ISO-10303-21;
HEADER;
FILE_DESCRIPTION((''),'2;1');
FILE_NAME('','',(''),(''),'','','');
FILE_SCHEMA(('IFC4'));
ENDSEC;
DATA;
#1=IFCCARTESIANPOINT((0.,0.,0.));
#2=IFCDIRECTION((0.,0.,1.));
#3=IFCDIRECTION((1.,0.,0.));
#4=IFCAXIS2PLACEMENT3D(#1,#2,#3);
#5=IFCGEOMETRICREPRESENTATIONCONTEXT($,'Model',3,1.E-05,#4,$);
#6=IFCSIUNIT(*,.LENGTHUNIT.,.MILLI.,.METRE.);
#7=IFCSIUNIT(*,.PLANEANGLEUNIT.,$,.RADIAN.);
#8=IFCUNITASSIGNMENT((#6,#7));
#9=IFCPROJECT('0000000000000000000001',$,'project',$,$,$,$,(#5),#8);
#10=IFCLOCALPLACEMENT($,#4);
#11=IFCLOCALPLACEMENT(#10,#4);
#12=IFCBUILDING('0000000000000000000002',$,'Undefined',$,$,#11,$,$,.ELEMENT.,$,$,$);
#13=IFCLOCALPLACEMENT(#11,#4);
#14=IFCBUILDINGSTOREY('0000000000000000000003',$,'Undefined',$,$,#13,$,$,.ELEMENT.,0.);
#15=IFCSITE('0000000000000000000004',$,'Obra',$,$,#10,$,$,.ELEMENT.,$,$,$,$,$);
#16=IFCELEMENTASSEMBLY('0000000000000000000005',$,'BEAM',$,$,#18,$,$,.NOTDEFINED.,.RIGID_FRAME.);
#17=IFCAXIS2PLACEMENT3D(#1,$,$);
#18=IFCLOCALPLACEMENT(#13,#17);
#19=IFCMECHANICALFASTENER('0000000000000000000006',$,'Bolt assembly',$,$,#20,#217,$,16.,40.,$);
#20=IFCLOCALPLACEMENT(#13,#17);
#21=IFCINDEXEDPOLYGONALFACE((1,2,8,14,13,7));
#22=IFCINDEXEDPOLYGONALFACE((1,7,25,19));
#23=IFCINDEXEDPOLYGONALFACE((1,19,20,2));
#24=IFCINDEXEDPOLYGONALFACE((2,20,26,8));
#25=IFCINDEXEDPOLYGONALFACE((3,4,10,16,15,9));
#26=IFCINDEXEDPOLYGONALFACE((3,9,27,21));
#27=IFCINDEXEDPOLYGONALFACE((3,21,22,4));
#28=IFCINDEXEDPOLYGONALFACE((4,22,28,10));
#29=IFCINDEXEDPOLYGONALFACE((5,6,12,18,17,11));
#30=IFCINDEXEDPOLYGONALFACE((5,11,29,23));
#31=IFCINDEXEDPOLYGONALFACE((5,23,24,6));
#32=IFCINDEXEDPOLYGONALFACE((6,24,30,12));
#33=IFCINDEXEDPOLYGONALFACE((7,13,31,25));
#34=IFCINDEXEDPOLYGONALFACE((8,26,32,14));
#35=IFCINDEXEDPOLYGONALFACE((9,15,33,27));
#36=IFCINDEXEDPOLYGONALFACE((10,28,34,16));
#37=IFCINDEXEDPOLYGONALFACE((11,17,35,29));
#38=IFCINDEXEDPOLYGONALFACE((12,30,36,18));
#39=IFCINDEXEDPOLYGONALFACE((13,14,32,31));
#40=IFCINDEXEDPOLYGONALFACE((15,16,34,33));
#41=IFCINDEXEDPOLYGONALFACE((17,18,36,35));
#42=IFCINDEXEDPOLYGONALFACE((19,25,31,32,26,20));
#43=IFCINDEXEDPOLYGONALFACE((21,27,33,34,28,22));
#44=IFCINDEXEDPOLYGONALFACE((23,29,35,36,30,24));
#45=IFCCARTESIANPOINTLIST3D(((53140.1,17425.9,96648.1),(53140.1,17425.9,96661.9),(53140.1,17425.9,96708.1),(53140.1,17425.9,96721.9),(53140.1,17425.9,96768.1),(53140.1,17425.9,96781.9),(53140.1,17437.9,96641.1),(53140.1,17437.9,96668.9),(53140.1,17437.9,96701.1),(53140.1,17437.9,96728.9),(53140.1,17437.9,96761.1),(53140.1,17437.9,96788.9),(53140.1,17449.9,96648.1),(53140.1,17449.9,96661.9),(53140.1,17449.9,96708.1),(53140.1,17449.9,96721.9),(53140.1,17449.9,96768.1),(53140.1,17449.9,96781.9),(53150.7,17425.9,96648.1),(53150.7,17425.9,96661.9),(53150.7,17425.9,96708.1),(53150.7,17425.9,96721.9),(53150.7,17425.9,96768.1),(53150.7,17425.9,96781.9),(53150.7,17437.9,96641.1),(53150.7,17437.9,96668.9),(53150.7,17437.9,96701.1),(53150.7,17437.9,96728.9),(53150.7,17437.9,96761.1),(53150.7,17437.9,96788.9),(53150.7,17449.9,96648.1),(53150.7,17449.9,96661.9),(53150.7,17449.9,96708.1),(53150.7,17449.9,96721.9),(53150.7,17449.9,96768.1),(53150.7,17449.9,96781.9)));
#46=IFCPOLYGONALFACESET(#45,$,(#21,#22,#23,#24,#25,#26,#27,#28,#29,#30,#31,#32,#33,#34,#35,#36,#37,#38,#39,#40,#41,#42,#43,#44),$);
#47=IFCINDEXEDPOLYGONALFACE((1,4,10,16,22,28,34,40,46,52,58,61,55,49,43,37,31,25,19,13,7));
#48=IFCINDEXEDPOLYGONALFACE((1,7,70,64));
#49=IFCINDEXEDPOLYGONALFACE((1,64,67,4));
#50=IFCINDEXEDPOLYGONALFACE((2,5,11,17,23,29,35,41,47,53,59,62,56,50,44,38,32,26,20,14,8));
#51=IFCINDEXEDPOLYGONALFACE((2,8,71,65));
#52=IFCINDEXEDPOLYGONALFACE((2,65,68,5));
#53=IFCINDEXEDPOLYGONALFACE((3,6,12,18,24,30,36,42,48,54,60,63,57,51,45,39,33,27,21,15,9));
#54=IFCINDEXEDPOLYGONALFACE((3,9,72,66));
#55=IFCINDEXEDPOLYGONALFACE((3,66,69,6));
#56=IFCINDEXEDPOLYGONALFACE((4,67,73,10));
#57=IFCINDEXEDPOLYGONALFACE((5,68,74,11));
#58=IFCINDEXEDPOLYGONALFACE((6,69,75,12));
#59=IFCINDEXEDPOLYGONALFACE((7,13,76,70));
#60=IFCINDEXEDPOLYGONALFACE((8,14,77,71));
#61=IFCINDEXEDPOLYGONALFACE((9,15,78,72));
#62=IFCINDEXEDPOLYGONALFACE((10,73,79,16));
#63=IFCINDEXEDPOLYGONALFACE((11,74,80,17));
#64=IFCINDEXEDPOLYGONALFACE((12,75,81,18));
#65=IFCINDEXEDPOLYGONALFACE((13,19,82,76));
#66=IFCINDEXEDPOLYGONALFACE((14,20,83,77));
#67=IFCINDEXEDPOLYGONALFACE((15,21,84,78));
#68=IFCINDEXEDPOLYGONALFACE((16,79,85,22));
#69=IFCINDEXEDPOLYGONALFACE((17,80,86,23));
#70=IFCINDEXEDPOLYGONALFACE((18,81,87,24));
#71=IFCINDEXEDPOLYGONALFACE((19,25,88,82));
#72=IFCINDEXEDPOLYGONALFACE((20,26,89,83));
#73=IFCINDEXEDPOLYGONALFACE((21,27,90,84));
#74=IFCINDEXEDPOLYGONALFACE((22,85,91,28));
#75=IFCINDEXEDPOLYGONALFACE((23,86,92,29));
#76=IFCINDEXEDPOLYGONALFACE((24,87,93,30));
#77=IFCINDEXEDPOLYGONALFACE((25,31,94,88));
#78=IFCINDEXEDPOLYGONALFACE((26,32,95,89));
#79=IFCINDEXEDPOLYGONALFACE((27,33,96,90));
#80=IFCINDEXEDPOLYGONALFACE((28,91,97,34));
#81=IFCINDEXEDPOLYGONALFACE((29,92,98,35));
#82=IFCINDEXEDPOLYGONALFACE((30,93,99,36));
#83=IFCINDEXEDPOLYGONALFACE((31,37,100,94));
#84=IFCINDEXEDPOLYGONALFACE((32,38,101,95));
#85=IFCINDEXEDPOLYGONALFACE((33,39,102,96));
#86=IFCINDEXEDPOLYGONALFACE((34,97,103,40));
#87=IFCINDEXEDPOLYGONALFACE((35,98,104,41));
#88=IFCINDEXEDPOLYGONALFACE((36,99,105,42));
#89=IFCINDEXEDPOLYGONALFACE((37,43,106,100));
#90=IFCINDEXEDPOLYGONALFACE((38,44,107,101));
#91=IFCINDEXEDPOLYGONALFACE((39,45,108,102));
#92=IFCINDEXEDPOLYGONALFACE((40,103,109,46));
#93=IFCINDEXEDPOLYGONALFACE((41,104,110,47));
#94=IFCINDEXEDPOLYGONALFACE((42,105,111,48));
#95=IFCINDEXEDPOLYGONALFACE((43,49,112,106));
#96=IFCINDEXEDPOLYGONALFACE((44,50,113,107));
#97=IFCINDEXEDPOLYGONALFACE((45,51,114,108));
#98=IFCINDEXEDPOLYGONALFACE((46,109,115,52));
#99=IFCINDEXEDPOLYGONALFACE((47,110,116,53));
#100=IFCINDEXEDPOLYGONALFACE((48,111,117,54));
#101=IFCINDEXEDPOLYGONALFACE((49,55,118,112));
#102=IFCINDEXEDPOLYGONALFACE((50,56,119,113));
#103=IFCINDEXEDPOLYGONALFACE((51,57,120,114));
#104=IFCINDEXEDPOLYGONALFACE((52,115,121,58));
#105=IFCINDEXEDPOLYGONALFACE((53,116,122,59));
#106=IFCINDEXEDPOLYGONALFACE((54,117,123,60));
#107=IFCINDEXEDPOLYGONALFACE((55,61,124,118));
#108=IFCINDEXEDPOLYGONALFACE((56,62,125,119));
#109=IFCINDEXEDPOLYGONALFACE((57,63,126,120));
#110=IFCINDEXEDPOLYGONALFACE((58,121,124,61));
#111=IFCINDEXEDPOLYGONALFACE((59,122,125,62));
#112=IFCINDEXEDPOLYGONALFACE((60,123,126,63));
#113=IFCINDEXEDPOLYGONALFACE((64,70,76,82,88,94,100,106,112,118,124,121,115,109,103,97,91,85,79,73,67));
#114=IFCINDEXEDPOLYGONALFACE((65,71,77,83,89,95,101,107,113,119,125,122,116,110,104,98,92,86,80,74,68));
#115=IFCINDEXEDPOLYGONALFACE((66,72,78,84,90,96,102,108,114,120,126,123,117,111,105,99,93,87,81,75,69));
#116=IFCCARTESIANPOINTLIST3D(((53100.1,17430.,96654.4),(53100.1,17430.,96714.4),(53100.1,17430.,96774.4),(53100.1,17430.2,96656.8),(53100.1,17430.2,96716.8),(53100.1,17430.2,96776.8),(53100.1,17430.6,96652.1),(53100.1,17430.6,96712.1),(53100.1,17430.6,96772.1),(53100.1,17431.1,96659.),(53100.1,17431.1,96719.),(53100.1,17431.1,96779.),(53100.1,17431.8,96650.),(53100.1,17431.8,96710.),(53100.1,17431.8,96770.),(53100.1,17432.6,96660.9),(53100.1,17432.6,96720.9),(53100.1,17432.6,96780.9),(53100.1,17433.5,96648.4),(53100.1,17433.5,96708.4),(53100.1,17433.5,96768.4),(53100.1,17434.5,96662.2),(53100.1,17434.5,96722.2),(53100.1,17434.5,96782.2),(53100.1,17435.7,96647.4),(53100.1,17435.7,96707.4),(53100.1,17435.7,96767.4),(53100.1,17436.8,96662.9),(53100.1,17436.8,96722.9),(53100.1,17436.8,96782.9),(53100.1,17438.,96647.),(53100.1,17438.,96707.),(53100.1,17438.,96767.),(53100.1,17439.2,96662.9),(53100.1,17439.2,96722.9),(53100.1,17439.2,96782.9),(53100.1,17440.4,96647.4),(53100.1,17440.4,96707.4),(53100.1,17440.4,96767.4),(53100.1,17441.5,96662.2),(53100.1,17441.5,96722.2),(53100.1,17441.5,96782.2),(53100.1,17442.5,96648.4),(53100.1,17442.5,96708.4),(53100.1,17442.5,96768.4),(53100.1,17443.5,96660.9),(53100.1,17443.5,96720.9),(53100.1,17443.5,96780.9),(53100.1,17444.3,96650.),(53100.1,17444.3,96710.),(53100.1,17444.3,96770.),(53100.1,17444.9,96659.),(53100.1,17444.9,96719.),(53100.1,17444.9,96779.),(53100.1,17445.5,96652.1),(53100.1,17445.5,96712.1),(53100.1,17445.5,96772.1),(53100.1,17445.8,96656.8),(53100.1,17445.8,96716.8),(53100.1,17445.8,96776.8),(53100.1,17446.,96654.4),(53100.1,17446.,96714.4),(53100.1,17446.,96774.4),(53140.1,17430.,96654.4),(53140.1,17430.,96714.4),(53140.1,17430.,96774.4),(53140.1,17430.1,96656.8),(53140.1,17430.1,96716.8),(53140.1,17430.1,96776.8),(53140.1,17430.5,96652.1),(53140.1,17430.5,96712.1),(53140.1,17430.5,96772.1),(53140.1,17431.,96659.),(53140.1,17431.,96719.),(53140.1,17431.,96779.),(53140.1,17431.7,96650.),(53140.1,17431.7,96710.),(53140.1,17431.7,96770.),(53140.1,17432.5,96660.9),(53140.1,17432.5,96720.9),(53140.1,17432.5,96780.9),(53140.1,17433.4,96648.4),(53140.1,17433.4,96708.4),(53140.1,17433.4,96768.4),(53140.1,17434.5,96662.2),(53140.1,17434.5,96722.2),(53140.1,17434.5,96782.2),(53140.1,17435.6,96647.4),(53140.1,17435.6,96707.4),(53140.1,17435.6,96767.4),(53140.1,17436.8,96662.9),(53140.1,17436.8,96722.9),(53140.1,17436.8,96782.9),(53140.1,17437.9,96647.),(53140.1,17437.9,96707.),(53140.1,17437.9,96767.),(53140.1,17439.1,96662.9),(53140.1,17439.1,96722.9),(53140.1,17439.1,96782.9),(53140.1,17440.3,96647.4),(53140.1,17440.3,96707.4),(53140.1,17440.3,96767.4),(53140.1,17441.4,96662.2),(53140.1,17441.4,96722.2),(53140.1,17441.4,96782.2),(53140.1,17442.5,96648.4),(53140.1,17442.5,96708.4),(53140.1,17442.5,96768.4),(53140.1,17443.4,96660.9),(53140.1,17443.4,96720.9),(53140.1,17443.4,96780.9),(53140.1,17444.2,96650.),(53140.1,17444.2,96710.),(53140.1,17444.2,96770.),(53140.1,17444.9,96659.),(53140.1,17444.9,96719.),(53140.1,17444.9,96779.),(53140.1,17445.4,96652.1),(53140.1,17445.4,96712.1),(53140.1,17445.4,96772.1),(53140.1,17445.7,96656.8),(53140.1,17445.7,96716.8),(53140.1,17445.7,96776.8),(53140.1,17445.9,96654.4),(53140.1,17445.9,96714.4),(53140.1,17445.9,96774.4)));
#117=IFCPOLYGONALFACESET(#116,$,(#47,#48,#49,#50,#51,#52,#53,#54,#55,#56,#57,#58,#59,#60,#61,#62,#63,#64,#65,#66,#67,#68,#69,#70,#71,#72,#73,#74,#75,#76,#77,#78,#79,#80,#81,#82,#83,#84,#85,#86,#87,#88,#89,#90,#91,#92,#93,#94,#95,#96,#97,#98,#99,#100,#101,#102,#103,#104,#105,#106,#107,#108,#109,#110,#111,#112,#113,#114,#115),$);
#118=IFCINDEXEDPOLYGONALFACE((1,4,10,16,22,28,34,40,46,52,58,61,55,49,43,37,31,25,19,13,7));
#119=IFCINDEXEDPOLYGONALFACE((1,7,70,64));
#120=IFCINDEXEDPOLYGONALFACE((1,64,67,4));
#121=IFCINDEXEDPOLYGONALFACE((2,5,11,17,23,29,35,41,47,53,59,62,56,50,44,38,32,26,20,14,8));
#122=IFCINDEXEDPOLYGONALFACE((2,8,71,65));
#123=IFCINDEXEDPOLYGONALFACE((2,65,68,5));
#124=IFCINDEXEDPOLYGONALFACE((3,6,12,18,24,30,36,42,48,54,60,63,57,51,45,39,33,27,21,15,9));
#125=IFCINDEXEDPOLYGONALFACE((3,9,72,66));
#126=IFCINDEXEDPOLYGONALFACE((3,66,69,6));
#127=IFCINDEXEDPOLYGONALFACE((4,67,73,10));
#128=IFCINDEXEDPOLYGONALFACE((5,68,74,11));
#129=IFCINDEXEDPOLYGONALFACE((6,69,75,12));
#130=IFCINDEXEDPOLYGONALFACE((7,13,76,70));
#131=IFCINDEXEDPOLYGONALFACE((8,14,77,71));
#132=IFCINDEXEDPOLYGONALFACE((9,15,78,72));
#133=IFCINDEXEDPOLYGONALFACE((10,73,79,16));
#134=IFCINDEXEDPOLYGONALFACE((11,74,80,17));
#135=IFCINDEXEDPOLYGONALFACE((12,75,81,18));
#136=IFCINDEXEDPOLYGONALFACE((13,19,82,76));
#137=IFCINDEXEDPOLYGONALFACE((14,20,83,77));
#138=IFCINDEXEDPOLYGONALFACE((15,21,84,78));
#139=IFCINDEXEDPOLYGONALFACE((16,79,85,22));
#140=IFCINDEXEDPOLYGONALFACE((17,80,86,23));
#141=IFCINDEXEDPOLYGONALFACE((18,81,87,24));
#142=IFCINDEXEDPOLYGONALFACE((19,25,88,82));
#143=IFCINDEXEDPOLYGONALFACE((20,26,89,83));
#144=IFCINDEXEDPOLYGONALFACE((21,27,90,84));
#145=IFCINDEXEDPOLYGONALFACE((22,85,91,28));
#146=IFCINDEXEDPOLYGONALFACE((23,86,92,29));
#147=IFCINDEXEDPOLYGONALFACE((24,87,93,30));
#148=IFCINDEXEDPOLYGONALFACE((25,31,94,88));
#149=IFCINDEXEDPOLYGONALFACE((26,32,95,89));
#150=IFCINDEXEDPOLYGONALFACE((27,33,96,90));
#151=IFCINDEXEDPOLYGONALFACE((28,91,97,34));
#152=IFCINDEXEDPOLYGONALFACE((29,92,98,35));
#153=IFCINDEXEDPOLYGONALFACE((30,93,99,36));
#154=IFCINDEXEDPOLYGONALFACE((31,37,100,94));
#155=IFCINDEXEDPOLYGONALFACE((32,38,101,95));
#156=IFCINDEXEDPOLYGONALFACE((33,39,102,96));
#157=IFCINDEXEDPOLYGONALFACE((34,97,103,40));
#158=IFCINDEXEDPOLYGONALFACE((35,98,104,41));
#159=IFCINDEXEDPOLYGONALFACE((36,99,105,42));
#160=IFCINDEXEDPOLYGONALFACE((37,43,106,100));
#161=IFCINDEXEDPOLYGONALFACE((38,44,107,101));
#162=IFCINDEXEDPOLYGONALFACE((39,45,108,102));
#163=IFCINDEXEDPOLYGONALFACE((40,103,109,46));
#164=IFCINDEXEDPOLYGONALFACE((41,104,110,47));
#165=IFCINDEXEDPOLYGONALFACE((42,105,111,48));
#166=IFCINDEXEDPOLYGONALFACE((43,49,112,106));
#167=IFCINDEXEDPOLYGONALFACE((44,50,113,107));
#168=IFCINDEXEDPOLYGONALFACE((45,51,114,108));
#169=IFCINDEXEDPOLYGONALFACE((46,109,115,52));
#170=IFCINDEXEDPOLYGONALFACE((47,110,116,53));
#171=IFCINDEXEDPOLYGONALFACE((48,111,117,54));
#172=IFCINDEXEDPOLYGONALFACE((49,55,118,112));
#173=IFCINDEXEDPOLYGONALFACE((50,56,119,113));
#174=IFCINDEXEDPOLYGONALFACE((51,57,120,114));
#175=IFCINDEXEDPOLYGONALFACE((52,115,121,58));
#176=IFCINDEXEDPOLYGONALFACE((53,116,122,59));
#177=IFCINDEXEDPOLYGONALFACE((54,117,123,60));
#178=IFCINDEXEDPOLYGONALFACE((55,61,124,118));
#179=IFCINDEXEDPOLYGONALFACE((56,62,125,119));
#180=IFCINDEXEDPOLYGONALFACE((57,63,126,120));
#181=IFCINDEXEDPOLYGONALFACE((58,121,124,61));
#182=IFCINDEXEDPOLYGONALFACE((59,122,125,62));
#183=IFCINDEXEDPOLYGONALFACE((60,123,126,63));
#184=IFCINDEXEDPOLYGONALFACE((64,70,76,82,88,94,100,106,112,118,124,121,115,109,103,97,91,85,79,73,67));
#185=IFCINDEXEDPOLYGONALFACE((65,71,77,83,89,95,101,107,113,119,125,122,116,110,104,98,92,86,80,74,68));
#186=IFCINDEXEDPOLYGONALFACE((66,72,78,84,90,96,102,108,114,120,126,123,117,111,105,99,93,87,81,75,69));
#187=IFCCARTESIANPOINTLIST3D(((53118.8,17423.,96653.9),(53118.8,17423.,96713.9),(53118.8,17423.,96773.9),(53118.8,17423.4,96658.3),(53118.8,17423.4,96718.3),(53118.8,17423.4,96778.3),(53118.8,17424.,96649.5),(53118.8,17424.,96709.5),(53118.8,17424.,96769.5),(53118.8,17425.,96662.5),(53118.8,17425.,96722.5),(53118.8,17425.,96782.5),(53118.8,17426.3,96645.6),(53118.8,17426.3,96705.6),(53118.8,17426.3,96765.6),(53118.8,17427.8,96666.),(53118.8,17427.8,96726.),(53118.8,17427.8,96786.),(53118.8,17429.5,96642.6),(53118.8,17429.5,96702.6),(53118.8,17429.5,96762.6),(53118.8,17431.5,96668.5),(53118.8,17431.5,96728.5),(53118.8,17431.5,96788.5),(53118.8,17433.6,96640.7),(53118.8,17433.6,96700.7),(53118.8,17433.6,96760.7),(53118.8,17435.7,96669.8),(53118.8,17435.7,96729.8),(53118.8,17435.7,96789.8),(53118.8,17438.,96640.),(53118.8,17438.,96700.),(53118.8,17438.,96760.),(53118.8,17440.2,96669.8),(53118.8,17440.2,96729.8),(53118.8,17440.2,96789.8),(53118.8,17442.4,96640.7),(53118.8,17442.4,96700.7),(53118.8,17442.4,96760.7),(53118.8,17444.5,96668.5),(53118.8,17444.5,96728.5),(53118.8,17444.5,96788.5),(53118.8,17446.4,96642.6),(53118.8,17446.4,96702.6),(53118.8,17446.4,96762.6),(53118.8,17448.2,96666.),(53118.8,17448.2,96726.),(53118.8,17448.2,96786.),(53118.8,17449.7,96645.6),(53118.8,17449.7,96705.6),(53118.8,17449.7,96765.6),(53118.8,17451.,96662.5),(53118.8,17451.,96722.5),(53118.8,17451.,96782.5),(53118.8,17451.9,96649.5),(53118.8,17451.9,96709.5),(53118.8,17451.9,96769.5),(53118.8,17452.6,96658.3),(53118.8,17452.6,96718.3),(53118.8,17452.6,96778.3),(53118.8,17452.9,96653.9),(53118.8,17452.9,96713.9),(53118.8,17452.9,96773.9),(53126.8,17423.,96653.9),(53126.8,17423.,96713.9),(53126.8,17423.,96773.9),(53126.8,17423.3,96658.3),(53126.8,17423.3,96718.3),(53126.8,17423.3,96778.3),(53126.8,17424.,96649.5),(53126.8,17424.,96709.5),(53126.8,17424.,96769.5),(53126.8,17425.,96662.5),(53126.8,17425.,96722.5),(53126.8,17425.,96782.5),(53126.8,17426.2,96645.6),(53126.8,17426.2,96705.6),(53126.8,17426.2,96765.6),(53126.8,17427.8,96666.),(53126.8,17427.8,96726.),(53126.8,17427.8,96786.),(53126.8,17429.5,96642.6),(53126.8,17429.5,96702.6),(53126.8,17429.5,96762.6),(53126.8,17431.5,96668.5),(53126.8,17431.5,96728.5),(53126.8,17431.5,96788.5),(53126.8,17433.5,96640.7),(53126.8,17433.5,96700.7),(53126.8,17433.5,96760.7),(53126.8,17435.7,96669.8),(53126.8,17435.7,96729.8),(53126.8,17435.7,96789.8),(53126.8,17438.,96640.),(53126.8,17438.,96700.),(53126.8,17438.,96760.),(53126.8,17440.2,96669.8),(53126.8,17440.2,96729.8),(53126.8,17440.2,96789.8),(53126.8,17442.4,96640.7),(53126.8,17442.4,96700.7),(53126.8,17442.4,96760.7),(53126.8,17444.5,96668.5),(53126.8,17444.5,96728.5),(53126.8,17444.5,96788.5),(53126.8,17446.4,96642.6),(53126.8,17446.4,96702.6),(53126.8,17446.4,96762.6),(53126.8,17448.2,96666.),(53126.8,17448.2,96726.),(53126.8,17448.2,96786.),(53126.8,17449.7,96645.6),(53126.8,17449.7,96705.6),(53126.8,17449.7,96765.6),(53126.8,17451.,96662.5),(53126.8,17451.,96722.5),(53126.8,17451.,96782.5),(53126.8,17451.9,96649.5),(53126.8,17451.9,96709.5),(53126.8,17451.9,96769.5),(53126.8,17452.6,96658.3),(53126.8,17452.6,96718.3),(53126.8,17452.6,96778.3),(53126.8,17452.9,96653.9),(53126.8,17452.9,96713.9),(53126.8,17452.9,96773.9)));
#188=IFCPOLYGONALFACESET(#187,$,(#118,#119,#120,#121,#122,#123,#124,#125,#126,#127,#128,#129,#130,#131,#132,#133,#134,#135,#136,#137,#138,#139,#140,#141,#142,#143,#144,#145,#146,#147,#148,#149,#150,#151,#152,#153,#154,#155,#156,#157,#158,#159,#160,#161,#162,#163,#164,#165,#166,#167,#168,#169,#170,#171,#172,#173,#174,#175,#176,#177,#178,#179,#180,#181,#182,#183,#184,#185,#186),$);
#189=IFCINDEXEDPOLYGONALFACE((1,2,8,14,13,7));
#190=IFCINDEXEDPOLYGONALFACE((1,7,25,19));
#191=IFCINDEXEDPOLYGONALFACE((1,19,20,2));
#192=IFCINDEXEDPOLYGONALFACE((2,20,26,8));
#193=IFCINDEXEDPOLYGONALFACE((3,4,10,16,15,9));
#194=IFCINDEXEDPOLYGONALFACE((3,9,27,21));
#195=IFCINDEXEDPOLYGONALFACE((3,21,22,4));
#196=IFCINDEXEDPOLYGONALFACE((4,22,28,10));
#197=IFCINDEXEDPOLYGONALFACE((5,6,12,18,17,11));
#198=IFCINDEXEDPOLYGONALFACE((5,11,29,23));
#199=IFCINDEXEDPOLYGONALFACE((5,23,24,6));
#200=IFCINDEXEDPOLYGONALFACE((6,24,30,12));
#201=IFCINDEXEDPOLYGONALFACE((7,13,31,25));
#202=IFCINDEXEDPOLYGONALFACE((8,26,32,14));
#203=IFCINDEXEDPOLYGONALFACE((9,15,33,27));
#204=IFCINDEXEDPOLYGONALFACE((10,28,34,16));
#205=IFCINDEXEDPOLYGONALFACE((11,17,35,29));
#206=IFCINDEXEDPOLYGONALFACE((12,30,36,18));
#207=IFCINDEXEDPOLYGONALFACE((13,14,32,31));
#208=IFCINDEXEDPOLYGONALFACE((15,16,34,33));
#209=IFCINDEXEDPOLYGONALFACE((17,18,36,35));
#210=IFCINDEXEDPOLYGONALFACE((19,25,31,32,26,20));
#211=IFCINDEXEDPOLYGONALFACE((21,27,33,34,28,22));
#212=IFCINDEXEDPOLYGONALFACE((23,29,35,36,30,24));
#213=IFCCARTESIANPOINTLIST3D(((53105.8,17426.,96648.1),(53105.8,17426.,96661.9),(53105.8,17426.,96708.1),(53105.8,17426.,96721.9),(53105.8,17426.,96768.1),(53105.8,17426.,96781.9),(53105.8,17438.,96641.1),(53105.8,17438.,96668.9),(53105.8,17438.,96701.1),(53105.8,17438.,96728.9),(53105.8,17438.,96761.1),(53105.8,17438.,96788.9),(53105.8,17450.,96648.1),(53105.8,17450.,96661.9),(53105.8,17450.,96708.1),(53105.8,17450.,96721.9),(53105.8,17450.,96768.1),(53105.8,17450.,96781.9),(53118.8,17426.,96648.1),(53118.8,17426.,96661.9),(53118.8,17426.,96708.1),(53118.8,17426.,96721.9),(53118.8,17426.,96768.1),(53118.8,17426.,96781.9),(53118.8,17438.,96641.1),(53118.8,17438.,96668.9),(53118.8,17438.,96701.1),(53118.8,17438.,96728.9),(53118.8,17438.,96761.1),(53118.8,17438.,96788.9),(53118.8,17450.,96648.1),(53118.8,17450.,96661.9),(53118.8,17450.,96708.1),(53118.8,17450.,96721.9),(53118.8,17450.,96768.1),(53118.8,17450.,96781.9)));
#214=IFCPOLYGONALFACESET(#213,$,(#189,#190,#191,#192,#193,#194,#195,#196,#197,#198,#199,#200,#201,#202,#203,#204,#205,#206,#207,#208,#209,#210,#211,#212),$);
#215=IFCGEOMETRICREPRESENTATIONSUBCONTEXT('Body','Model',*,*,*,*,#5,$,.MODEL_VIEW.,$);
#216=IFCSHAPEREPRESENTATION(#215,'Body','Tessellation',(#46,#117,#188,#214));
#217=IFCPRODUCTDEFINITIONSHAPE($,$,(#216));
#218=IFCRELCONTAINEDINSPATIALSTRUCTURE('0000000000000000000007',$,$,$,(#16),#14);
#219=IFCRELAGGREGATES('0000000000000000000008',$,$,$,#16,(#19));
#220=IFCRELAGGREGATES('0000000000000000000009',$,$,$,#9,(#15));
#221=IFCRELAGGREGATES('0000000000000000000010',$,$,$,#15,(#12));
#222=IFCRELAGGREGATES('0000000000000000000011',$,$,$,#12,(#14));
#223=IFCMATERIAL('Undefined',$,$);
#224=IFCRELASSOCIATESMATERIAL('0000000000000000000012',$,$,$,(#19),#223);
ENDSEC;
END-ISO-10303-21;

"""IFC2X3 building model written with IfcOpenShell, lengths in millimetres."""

from ifc_helpers import new_model, si_unit, frame, origin_with_axes, origin_2d_with_axis, place, context, subcontext, project, spatial, polyline, circle, outline, extrude, source, transform, mapped, material, element, aggregate, save


model = new_model("IFC2X3")

# Units and contexts
model_context = context("Model", 3, precision=1e-05, world=origin_with_axes())
body_context = subcontext(model_context, "Body", "Model", "MODEL_VIEW")
ifc_project = project(units=[si_unit("LENGTHUNIT", "METRE", prefix="MILLI"), si_unit("PLANEANGLEUNIT", "RADIAN")], contexts=[model_context])

# Site, building, storey
site_placement = place(None, origin_with_axes())
site = spatial("IfcSite", under=ifc_project, at=site_placement, Name="Obra", CompositionType="ELEMENT")
building_placement = place(site_placement, origin_with_axes())
building = spatial("IfcBuilding", under=site, at=building_placement, Name="Undefined", CompositionType="ELEMENT")
storey_placement = place(building_placement, origin_with_axes())
storey = spatial("IfcBuildingStorey", under=building, at=storey_placement, Name="Undefined", CompositionType="ELEMENT", Elevation=0.0)

# Shared definitions
ifc_material_1 = material(Name="Undefined")

# Element assembly, mechanical fastener
assembly_1_placement = place(storey_placement, origin_with_axes())
assembly_1 = element("IfcElementAssembly", 1, at=assembly_1_placement, inside=storey, Name="BEAM", AssemblyPlace="NOTDEFINED", PredefinedType="RIGID_FRAME")
shared_shape_1 = source(origin_with_axes(), body_context, "Body", "SweptSolid", [
    extrude(outline(polyline([(13.9, 0.0), (6.9, 12.0), (-6.9, 12.0), (-13.9, 0.0), (-6.9, -12.0), (6.9, -12.0), (13.9, 0.0)])), frame((0.0, -19.7, 0.0), z_axis=(0.0, 1.0, 0.0), x_axis=(1.0, 0.0, 0.0)), (0.0, 0.0, 1.0), 10.6),
    extrude(circle(Radius=8.0, at=origin_2d_with_axis()), frame((0.0, -9.1, 0.0), z_axis=(0.0, 1.0, 0.0), x_axis=(1.0, 0.0, 0.0)), (0.0, 0.0, 1.0), 40.0),
    extrude(circle(Radius=15.0, at=origin_2d_with_axis()), frame((0.0, 4.2, 0.0), z_axis=(0.0, 1.0, 0.0), x_axis=(1.0, 0.0, 0.0)), (0.0, 0.0, 1.0), 8.0),
    extrude(outline(polyline([(13.9, 0.0), (6.9, 12.0), (-6.9, 12.0), (-13.9, 0.0), (-6.9, -12.0), (6.9, -12.0), (13.9, 0.0)])), frame((0.0, 12.2, 0.0), z_axis=(0.0, 1.0, 0.0), x_axis=(1.0, 0.0, 0.0)), (0.0, 0.0, 1.0), 13.0),
])
mechanical_fastener_1_placement = place(assembly_1_placement, frame((53130.9, 17388.0, 96835.0), z_axis=(0.001649, 0.999999, 0.0), x_axis=(0.0, 0.0, -1.0)))
mechanical_fastener_1 = element("IfcMechanicalFastener", 2, at=mechanical_fastener_1_placement, material=ifc_material_1, Name="Bolt assembly", NominalDiameter=16.0, NominalLength=40.0, context=body_context, shape_type="MappedRepresentation", body=[
    mapped(shared_shape_1, transform((60.0, 0.0, 50.0))),
    mapped(shared_shape_1, transform((120.0, 0.0, 50.0))),
    mapped(shared_shape_1, transform((180.0, 0.0, 50.0))),
])
aggregate(assembly_1, [mechanical_fastener_1])

save(model, "model.ifc")
